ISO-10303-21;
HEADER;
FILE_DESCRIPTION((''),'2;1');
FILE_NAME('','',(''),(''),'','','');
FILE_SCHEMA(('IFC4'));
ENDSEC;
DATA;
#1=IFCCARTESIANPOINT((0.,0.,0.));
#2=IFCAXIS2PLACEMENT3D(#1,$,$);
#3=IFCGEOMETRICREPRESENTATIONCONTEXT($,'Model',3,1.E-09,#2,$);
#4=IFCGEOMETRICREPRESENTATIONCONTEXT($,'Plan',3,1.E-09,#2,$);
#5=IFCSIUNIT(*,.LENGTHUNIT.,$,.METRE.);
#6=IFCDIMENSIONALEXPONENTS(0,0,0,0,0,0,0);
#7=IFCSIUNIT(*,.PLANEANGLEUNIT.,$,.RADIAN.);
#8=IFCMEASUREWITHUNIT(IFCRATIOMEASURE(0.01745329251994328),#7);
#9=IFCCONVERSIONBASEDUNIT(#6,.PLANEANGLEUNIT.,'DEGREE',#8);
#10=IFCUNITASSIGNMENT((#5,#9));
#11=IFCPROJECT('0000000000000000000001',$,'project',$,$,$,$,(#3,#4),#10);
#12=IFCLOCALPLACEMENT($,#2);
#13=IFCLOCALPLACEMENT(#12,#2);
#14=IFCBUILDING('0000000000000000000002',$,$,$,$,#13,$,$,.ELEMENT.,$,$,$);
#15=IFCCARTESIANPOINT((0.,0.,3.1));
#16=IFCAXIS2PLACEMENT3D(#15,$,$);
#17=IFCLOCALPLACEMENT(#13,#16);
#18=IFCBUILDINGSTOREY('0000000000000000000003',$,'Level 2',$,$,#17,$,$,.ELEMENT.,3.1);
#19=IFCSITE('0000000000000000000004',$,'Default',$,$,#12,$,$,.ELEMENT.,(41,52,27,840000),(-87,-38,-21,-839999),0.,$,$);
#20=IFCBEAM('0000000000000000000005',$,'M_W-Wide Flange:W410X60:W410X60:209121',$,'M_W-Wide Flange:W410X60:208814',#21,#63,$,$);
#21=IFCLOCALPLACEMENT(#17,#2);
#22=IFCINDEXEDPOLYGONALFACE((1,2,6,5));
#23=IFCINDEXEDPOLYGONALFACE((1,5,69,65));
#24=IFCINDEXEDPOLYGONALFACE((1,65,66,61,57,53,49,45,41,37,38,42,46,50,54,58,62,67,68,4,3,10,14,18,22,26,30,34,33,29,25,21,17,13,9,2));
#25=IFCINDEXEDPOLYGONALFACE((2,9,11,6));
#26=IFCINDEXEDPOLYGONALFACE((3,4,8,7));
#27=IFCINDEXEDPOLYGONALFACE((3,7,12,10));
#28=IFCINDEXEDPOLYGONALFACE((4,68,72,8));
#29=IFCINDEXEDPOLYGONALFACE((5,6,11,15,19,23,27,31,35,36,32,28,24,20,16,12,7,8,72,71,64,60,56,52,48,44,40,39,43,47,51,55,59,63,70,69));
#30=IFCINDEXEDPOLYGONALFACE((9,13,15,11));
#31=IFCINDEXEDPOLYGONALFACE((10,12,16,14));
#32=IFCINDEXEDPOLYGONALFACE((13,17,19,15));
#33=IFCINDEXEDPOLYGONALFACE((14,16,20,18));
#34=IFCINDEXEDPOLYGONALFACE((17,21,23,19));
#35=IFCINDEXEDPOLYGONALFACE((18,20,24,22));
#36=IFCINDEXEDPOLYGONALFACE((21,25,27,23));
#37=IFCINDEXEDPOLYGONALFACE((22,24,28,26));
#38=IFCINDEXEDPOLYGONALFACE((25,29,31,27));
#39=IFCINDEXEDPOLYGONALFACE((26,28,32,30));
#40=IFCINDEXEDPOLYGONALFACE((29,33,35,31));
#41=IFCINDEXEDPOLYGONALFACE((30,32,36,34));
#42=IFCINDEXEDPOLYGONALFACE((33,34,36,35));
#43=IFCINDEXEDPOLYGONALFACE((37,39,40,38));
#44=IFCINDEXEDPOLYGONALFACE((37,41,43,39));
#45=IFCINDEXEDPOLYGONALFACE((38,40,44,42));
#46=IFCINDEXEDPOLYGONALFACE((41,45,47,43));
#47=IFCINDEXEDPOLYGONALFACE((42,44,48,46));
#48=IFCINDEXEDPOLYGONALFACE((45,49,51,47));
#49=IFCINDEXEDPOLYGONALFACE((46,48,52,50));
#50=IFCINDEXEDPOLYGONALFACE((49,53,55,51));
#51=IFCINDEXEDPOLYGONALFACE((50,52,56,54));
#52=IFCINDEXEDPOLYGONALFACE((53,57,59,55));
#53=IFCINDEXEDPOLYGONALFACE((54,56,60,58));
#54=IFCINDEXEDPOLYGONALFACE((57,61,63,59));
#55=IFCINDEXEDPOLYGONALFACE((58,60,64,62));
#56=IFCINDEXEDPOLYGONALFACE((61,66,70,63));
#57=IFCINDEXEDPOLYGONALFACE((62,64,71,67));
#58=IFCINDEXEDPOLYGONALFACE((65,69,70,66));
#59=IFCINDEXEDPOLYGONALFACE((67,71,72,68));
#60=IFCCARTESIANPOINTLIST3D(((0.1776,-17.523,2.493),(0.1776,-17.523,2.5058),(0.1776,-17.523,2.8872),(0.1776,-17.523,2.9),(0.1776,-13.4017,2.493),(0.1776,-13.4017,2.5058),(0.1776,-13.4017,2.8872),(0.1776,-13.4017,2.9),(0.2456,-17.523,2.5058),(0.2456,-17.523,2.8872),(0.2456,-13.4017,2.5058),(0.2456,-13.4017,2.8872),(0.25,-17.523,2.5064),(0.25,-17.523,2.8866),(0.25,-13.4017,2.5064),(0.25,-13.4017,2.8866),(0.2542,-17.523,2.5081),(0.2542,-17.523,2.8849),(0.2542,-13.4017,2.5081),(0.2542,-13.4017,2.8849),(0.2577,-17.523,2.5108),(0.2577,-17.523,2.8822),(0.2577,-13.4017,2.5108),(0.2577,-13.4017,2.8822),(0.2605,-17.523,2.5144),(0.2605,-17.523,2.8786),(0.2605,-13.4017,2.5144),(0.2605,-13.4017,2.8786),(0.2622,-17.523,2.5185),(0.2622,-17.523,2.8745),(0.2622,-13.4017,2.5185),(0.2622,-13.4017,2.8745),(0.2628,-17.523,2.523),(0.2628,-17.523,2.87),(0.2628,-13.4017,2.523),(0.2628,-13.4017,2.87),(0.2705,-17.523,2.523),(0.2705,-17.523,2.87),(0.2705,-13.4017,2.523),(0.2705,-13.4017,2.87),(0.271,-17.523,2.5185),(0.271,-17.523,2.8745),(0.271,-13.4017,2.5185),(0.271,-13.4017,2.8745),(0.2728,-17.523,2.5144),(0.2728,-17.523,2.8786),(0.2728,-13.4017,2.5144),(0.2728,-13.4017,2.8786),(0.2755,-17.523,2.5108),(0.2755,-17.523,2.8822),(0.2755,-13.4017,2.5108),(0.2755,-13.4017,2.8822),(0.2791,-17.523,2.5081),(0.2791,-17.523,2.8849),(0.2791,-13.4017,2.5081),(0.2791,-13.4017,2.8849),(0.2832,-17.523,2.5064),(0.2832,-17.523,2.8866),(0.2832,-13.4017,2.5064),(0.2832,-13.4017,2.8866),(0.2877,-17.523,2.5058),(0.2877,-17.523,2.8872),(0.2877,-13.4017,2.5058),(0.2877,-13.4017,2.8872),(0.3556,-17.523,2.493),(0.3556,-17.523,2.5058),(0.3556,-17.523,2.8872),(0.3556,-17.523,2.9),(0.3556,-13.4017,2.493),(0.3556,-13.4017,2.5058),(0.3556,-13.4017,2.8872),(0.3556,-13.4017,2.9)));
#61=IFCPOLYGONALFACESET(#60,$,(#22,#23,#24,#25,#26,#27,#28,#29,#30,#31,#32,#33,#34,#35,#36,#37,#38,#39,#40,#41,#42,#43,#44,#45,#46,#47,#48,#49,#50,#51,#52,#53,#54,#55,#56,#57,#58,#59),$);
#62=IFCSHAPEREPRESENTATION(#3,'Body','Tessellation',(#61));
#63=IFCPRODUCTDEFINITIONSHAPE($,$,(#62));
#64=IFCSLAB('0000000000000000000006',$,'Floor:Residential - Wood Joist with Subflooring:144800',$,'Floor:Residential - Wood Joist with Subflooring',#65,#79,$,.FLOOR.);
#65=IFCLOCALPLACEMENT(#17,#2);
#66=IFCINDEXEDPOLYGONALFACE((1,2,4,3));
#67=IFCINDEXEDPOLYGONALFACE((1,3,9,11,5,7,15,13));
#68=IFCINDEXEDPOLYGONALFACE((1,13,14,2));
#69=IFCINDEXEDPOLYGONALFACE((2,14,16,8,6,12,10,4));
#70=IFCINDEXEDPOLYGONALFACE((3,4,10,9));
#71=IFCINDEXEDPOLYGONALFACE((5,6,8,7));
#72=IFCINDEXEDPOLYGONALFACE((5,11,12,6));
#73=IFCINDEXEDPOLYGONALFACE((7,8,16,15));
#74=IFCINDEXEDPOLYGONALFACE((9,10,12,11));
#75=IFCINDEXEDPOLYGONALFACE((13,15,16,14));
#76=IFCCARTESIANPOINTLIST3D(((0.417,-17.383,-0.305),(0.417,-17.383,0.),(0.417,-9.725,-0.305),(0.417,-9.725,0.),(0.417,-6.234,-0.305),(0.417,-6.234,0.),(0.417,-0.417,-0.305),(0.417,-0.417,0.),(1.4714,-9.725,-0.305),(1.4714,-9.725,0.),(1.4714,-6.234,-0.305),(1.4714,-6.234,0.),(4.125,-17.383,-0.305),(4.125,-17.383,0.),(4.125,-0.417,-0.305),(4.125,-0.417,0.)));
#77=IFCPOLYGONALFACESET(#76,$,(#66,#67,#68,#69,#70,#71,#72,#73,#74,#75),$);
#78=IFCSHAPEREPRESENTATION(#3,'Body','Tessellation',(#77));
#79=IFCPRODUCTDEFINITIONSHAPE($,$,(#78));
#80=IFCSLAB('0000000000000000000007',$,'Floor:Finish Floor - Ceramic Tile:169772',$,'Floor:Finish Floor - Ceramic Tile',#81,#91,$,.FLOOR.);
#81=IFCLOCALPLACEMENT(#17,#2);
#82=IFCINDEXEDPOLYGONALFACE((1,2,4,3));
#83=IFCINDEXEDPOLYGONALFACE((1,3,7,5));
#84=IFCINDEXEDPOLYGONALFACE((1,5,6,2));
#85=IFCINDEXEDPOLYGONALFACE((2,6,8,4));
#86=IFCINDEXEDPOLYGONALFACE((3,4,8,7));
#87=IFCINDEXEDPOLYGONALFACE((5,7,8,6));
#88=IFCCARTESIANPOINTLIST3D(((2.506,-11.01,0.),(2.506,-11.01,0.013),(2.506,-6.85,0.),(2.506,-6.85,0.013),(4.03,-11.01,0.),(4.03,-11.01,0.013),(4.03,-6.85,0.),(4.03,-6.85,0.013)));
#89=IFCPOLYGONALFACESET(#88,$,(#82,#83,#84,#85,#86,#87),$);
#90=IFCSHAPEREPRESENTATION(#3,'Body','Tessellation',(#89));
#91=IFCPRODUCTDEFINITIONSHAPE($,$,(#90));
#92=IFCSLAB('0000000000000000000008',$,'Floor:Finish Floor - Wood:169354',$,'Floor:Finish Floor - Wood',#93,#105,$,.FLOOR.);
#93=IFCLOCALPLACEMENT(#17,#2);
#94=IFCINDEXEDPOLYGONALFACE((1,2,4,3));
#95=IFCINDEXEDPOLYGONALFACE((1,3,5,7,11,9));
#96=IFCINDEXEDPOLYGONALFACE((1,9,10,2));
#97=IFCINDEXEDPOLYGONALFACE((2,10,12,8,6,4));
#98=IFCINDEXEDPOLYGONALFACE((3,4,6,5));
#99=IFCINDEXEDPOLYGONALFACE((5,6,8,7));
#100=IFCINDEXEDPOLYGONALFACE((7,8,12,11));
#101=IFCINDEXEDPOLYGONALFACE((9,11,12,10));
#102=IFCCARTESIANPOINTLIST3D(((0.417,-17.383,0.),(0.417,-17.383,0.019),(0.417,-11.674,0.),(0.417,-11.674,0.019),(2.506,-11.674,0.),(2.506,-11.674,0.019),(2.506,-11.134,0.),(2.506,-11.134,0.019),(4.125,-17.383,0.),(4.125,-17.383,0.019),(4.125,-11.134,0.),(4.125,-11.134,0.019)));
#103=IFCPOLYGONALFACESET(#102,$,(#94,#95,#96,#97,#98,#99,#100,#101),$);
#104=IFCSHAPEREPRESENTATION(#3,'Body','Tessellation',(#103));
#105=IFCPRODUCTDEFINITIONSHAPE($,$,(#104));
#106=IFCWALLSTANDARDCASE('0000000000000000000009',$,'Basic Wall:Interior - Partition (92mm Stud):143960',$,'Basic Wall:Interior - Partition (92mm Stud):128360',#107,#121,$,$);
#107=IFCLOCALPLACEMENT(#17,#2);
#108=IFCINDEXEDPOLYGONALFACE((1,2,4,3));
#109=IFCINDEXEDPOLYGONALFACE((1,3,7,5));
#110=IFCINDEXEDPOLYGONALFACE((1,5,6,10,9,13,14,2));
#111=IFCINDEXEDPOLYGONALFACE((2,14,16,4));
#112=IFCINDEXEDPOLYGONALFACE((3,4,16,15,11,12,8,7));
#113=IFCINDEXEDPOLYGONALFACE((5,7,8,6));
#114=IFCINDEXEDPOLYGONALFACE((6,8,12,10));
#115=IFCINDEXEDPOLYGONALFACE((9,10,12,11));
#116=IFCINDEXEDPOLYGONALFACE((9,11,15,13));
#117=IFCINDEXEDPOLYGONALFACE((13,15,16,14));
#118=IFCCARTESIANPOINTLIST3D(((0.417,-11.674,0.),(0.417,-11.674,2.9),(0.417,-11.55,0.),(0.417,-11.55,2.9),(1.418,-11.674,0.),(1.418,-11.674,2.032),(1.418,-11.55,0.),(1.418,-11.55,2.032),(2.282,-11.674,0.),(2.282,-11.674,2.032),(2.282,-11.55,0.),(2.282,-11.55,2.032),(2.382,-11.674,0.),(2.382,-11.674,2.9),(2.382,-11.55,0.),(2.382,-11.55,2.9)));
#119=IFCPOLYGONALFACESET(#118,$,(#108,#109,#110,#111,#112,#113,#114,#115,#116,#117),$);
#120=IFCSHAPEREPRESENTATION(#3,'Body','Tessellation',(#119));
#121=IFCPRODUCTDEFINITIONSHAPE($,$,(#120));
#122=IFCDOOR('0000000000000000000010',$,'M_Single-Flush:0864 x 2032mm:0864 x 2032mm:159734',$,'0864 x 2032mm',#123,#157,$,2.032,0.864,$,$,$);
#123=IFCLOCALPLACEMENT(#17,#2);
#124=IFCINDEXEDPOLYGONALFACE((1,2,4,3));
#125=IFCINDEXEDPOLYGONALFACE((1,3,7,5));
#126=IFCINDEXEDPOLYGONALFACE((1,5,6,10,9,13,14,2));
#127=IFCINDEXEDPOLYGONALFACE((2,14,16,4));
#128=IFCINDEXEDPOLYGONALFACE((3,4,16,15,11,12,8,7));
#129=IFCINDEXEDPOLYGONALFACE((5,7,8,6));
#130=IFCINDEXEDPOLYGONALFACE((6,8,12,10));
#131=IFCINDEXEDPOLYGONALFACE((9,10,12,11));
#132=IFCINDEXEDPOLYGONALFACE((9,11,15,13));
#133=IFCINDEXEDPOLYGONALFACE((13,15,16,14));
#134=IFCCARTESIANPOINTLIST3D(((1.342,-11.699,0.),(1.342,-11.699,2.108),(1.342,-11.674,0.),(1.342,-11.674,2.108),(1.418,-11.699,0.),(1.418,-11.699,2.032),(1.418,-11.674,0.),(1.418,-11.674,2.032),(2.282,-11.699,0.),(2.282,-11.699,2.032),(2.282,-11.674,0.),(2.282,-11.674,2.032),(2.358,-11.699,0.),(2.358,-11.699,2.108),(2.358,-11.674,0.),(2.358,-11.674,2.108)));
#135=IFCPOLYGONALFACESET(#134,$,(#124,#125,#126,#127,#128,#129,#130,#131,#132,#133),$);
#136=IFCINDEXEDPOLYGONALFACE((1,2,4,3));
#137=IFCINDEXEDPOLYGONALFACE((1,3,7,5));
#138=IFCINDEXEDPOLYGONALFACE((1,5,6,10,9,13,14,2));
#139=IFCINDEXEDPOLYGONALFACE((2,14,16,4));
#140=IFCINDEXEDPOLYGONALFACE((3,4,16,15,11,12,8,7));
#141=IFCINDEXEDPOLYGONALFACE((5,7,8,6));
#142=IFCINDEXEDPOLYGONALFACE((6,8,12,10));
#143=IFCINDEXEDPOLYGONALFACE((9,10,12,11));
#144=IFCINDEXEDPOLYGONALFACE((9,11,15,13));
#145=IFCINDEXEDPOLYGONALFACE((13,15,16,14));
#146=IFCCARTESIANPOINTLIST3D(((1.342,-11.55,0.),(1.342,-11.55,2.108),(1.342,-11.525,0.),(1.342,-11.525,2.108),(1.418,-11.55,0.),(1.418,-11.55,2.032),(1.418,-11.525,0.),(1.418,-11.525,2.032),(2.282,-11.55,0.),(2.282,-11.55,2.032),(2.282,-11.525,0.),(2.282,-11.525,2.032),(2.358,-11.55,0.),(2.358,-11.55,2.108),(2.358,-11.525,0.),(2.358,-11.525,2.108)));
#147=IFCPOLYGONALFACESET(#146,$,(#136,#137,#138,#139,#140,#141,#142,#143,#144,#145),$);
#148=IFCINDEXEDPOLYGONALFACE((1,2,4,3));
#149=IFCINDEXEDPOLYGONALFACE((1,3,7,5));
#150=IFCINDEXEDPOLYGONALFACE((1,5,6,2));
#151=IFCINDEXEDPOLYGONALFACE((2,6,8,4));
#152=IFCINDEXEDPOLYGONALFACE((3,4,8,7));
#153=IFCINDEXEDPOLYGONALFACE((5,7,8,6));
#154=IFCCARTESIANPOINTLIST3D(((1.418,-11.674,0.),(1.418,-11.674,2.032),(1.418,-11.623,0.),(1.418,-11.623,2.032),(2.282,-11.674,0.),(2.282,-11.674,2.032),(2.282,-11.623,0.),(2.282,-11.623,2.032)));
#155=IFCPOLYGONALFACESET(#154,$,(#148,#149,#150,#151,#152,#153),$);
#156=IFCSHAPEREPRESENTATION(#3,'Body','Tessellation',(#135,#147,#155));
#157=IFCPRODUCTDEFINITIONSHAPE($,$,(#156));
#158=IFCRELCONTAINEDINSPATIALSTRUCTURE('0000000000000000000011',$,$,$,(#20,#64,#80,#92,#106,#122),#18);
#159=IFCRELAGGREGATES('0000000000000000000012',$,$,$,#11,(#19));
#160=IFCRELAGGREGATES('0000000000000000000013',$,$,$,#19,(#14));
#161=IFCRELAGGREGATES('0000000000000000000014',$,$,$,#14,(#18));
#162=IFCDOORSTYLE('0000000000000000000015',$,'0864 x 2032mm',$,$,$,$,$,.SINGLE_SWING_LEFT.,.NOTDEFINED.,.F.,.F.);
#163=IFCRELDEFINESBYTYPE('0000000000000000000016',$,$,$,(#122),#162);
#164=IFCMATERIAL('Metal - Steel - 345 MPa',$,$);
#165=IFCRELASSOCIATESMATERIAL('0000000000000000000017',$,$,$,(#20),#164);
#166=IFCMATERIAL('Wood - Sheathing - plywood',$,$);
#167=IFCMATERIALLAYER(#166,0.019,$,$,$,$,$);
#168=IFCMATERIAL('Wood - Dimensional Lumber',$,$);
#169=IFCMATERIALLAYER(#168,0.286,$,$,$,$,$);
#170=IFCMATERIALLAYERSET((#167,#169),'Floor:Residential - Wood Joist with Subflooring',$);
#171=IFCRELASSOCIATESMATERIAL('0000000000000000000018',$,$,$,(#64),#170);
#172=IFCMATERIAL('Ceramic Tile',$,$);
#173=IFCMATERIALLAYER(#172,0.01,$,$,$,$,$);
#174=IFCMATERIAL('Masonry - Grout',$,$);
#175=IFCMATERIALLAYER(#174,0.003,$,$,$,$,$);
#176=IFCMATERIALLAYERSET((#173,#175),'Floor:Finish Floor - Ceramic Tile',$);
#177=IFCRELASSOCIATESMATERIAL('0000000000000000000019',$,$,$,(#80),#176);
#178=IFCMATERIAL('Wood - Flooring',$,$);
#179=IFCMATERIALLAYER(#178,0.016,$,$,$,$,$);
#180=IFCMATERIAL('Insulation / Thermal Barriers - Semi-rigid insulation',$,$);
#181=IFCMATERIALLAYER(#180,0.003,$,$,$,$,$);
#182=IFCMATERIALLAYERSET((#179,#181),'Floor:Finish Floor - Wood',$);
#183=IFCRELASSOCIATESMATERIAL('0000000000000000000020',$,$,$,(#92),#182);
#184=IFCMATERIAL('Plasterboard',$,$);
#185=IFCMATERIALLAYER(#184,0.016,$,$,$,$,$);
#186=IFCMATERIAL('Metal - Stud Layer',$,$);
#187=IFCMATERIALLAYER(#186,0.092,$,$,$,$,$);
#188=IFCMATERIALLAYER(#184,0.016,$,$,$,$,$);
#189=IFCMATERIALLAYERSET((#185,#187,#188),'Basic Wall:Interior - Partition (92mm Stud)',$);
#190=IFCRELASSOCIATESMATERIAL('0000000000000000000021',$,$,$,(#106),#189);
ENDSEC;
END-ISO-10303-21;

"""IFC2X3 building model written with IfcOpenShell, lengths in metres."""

from ifc_helpers import new_model, entity, si_unit, converted_unit, frame, frame_2d, origin, origin_2d_with_axis, place, context, project, spatial, polyline, circle_curve, parameter, trimmed, segment, composite_curve, rectangle, outline, extrude, source, transform, mapped, material, layer, layer_set, layer_usage, type_object, type_shapes, element, fill, save


model = new_model("IFC2X3")

# Units and contexts
model_context = context("Model", 3, precision=1e-09, world=origin())
plan_context = context("Plan", 3, precision=1e-09, world=origin())
ifc_project = project(units=[si_unit("LENGTHUNIT", "METRE"), converted_unit("PLANEANGLEUNIT", "DEGREE", entity("IfcRatioMeasure", 0.01745329251994328), si_unit("PLANEANGLEUNIT", "RADIAN"), dimensions=[0, 0, 0, 0, 0, 0, 0])], contexts=[model_context, plan_context])

# Site, building, storey
site_placement = place(None, origin())
site = spatial("IfcSite", under=ifc_project, at=site_placement, Name="Default", CompositionType="ELEMENT", RefLatitude=(41, 52, 27, 840000), RefLongitude=(-87, -38, -21, -839999), RefElevation=0.0)
building_placement = place(site_placement, origin())
building = spatial("IfcBuilding", under=site, at=building_placement, CompositionType="ELEMENT")
storey_placement = place(building_placement, frame((0.0, 0.0, 3.1)))
storey = spatial("IfcBuildingStorey", under=building, at=storey_placement, Name="Level 2", CompositionType="ELEMENT", Elevation=3.1)

# Beam
ifc_material_1 = material(Name="Metal - Steel - 345 MPa")
beam_placement = place(storey_placement, frame((0.2666, -13.4017, 2.9), z_axis=(0.0, 0.0, 1.0), x_axis=(-1.0, 0.0, 0.0)))
element("IfcBeam", 1, at=beam_placement, inside=storey, material=ifc_material_1, Name="M_W-Wide Flange:W410X60:W410X60:209121", ObjectType="M_W-Wide Flange:W410X60:208814", context=model_context, shape_type="SweptSolid", body=[
    extrude(outline(composite_curve([segment(polyline([(0.1907, -0.089), (0.2035, -0.089)]), True, "CONTINUOUS"), segment(polyline([(0.2035, -0.089), (0.2035, 0.089)]), True, "CONTINUOUS"), segment(polyline([(0.2035, 0.089), (0.1907, 0.089)]), True, "CONTINUOUS"), segment(polyline([(0.1907, 0.089), (0.1907, 0.021)]), True, "CONTINUOUS"), segment(trimmed(circle_curve(frame_2d((0.1735, 0.021), x_axis=(1.0, 0.0)), 0.0172), [parameter(270.0)], [parameter(360.0)], True, "PARAMETER"), False, "CONTINUOUS"), segment(polyline([(0.1735, 0.0038), (-0.1735, 0.0038)]), True, "CONTINUOUS"), segment(trimmed(circle_curve(frame_2d((-0.1735, 0.021), x_axis=(0.0, -1.0)), 0.0172), [parameter(270.0)], [parameter(360.0)], True, "PARAMETER"), False, "CONTINUOUS"), segment(polyline([(-0.1907, 0.021), (-0.1907, 0.089)]), True, "CONTINUOUS"), segment(polyline([(-0.1907, 0.089), (-0.2035, 0.089)]), True, "CONTINUOUS"), segment(polyline([(-0.2035, 0.089), (-0.2035, -0.089)]), True, "CONTINUOUS"), segment(polyline([(-0.2035, -0.089), (-0.1907, -0.089)]), True, "CONTINUOUS"), segment(polyline([(-0.1907, -0.089), (-0.1907, -0.0211)]), True, "CONTINUOUS"), segment(trimmed(circle_curve(frame_2d((-0.1735, -0.0211), x_axis=(-1.0, 0.0)), 0.0172), [parameter(270.0)], [parameter(0.0)], True, "PARAMETER"), False, "CONTINUOUS"), segment(polyline([(-0.1735, -0.0039), (0.1735, -0.0039)]), True, "CONTINUOUS"), segment(trimmed(circle_curve(frame_2d((0.1735, -0.0211), x_axis=(0.0, 1.0)), 0.0172), [parameter(270.0)], [parameter(0.0)], True, "PARAMETER"), False, "CONTINUOUS"), segment(polyline([(0.1907, -0.0211), (0.1907, -0.089)]), True, "CONTINUOUS")], self_intersect=False)), frame((0.0, 4.1213, -0.2035), z_axis=(0.0, -1.0, 0.0), x_axis=(0.0, 0.0, -1.0)), (0.0, 0.0, 1.0), 4.1213),
])

# Slabs
ifc_material_2 = material(Name="Wood - Sheathing - plywood")
ifc_layer_1 = layer(ifc_material_2, 0.019)
ifc_material_3 = material(Name="Wood - Dimensional Lumber")
ifc_layer_2 = layer(ifc_material_3, 0.286)
ifc_layer_set_1 = layer_set([ifc_layer_1, ifc_layer_2], Name="Floor:Residential - Wood Joist with Subflooring")
ifc_layer_usage_1 = layer_usage(ifc_layer_set_1, "AXIS3", "POSITIVE", 0.0)
slab_1_placement = place(storey_placement, frame((0.417, -17.383, -0.305)))
element("IfcSlab", 2, at=slab_1_placement, inside=storey, material=ifc_layer_usage_1, Name="Floor:Residential - Wood Joist with Subflooring:144800", ObjectType="Floor:Residential - Wood Joist with Subflooring", PredefinedType="FLOOR", context=model_context, shape_type="SweptSolid", body=[
    extrude(outline(polyline([(-1.854, 8.483), (-1.854, -8.483), (1.854, -8.483), (1.854, -0.825), (0.7996, -0.825), (0.7996, 2.666), (1.854, 2.666), (1.854, 8.483), (-1.854, 8.483)])), frame((1.854, 8.483, 0.305), z_axis=(0.0, 0.0, -1.0), x_axis=(-1.0, 0.0, 0.0)), (0.0, 0.0, 1.0), 0.305),
])
ifc_material_4 = material(Name="Ceramic Tile")
ifc_layer_3 = layer(ifc_material_4, 0.01)
ifc_material_5 = material(Name="Masonry - Grout")
ifc_layer_4 = layer(ifc_material_5, 0.003)
ifc_layer_set_2 = layer_set([ifc_layer_3, ifc_layer_4], Name="Floor:Finish Floor - Ceramic Tile")
ifc_layer_usage_2 = layer_usage(ifc_layer_set_2, "AXIS3", "POSITIVE", 0.0)
slab_2_placement = place(storey_placement, frame((2.506, -11.01, 0.0)))
element("IfcSlab", 3, at=slab_2_placement, inside=storey, material=ifc_layer_usage_2, Name="Floor:Finish Floor - Ceramic Tile:169772", ObjectType="Floor:Finish Floor - Ceramic Tile", PredefinedType="FLOOR", context=model_context, shape_type="SweptSolid", body=[
    extrude(rectangle(XDim=4.16, YDim=1.524, at=frame_2d((0.0, 0.0), x_axis=(0.0, -1.0))), frame((0.762, 2.08, 0.013), z_axis=(0.0, 0.0, -1.0), x_axis=(-1.0, 0.0, 0.0)), (0.0, 0.0, 1.0), 0.013),
])
ifc_material_6 = material(Name="Wood - Flooring")
ifc_layer_5 = layer(ifc_material_6, 0.016)
ifc_material_7 = material(Name="Insulation / Thermal Barriers - Semi-rigid insulation")
ifc_layer_6 = layer(ifc_material_7, 0.003)
ifc_layer_set_3 = layer_set([ifc_layer_5, ifc_layer_6], Name="Floor:Finish Floor - Wood")
ifc_layer_usage_3 = layer_usage(ifc_layer_set_3, "AXIS3", "POSITIVE", 0.0)
slab_3_placement = place(storey_placement, frame((0.417, -17.383, 0.0)))
element("IfcSlab", 4, at=slab_3_placement, inside=storey, material=ifc_layer_usage_3, Name="Floor:Finish Floor - Wood:169354", ObjectType="Floor:Finish Floor - Wood", PredefinedType="FLOOR", context=model_context, shape_type="SweptSolid", body=[
    extrude(outline(polyline([(-1.854, -3.1245), (1.854, -3.1245), (1.854, 2.5845), (-0.235, 2.5845), (-0.235, 3.1245), (-1.854, 3.1245), (-1.854, -3.1245)])), frame((1.854, 3.1245, 0.019), z_axis=(0.0, 0.0, -1.0), x_axis=(-1.0, 0.0, 0.0)), (0.0, 0.0, 1.0), 0.019),
])

# Shared definitions
ifc_material_8 = material(Name="Metal - Stud Layer")
ifc_material_9 = material(Name="Plasterboard")

# Wall, opening, door
ifc_layer_7 = layer(ifc_material_9, 0.016)
ifc_layer_8 = layer(ifc_material_8, 0.092)
ifc_layer_9 = layer(ifc_material_9, 0.016)
ifc_layer_set_4 = layer_set([ifc_layer_7, ifc_layer_8, ifc_layer_9], Name="Basic Wall:Interior - Partition (92mm Stud)")
ifc_layer_usage_4 = layer_usage(ifc_layer_set_4, "AXIS2", "NEGATIVE", 0.062)
wall_1_placement = place(storey_placement, frame((2.382, -11.612, 0.0), z_axis=(0.0, 0.0, 1.0), x_axis=(-1.0, 0.0, 0.0)))
wall_1 = element("IfcWallStandardCase", 5, at=wall_1_placement, inside=storey, material=ifc_layer_usage_4, Name="Basic Wall:Interior - Partition (92mm Stud):143960", ObjectType="Basic Wall:Interior - Partition (92mm Stud):128360", context=model_context, shape_type="SweptSolid", body=[
    extrude(rectangle(XDim=1.965, YDim=0.124, at=frame_2d((0.9825, 0.0), x_axis=(-1.0, 0.0))), origin(), (0.0, 0.0, 1.0), 2.9),
])
opening_1_placement = place(wall_1_placement, frame((0.1, -0.062, 0.0)))
opening_1 = element("IfcOpeningElement", 6, at=opening_1_placement, cuts=wall_1, ObjectType="Opening", context=model_context, shape_type="SweptSolid", body=[
    extrude(rectangle(XDim=0.864, YDim=2.032, at=frame_2d((1.016, 0.432), x_axis=(0.0, -1.0))), frame((0.0, 0.0, 0.0), z_axis=(0.0, 1.0, 0.0), x_axis=(0.0, 0.0, 1.0)), (0.0, 0.0, 1.0), 0.124),
])
door_style = type_object("IfcDoorStyle", Name="0864 x 2032mm", ConstructionType="NOTDEFINED", OperationType="SINGLE_SWING_LEFT", ParameterTakesPrecedence=False, Sizeable=False)
shared_shape_1 = source(origin(), model_context, "Body", "SweptSolid", [
    extrude(outline(polyline([(-0.508, -1.073), (0.508, -1.073), (0.508, 1.035), (0.432, 1.035), (0.432, -0.997), (-0.432, -0.997), (-0.432, 1.035), (-0.508, 1.035), (-0.508, -1.073)])), frame((0.432, 0.149, 1.035), z_axis=(0.0, -1.0, 0.0), x_axis=(-1.0, 0.0, 0.0)), (0.0, 0.0, 1.0), 0.025),
    extrude(outline(polyline([(-1.073, -0.508), (1.035, -0.508), (1.035, -0.432), (-0.997, -0.432), (-0.997, 0.432), (1.035, 0.432), (1.035, 0.508), (-1.073, 0.508), (-1.073, -0.508)])), frame((0.432, 0.0, 1.035), z_axis=(0.0, -1.0, 0.0), x_axis=(0.0, 0.0, -1.0)), (0.0, 0.0, 1.0), 0.025),
    extrude(rectangle(XDim=0.864, YDim=0.051, at=origin_2d_with_axis()), frame((0.432, 0.0985, 0.0)), (0.0, 0.0, 1.0), 2.032),
])
type_shapes(door_style, [shared_shape_1])
door_placement = place(opening_1_placement, origin())
door = element("IfcDoor", 7, at=door_placement, inside=storey, type_object=door_style, Name="M_Single-Flush:0864 x 2032mm:0864 x 2032mm:159734", ObjectType="0864 x 2032mm", OverallHeight=2.032, OverallWidth=0.864, context=model_context, shape_type="MappedRepresentation", body=[
    mapped(shared_shape_1, transform((0.0, 0.0, 0.0), scale=1.0)),
])
fill(opening_1, door)

save(model, "model.ifc")
